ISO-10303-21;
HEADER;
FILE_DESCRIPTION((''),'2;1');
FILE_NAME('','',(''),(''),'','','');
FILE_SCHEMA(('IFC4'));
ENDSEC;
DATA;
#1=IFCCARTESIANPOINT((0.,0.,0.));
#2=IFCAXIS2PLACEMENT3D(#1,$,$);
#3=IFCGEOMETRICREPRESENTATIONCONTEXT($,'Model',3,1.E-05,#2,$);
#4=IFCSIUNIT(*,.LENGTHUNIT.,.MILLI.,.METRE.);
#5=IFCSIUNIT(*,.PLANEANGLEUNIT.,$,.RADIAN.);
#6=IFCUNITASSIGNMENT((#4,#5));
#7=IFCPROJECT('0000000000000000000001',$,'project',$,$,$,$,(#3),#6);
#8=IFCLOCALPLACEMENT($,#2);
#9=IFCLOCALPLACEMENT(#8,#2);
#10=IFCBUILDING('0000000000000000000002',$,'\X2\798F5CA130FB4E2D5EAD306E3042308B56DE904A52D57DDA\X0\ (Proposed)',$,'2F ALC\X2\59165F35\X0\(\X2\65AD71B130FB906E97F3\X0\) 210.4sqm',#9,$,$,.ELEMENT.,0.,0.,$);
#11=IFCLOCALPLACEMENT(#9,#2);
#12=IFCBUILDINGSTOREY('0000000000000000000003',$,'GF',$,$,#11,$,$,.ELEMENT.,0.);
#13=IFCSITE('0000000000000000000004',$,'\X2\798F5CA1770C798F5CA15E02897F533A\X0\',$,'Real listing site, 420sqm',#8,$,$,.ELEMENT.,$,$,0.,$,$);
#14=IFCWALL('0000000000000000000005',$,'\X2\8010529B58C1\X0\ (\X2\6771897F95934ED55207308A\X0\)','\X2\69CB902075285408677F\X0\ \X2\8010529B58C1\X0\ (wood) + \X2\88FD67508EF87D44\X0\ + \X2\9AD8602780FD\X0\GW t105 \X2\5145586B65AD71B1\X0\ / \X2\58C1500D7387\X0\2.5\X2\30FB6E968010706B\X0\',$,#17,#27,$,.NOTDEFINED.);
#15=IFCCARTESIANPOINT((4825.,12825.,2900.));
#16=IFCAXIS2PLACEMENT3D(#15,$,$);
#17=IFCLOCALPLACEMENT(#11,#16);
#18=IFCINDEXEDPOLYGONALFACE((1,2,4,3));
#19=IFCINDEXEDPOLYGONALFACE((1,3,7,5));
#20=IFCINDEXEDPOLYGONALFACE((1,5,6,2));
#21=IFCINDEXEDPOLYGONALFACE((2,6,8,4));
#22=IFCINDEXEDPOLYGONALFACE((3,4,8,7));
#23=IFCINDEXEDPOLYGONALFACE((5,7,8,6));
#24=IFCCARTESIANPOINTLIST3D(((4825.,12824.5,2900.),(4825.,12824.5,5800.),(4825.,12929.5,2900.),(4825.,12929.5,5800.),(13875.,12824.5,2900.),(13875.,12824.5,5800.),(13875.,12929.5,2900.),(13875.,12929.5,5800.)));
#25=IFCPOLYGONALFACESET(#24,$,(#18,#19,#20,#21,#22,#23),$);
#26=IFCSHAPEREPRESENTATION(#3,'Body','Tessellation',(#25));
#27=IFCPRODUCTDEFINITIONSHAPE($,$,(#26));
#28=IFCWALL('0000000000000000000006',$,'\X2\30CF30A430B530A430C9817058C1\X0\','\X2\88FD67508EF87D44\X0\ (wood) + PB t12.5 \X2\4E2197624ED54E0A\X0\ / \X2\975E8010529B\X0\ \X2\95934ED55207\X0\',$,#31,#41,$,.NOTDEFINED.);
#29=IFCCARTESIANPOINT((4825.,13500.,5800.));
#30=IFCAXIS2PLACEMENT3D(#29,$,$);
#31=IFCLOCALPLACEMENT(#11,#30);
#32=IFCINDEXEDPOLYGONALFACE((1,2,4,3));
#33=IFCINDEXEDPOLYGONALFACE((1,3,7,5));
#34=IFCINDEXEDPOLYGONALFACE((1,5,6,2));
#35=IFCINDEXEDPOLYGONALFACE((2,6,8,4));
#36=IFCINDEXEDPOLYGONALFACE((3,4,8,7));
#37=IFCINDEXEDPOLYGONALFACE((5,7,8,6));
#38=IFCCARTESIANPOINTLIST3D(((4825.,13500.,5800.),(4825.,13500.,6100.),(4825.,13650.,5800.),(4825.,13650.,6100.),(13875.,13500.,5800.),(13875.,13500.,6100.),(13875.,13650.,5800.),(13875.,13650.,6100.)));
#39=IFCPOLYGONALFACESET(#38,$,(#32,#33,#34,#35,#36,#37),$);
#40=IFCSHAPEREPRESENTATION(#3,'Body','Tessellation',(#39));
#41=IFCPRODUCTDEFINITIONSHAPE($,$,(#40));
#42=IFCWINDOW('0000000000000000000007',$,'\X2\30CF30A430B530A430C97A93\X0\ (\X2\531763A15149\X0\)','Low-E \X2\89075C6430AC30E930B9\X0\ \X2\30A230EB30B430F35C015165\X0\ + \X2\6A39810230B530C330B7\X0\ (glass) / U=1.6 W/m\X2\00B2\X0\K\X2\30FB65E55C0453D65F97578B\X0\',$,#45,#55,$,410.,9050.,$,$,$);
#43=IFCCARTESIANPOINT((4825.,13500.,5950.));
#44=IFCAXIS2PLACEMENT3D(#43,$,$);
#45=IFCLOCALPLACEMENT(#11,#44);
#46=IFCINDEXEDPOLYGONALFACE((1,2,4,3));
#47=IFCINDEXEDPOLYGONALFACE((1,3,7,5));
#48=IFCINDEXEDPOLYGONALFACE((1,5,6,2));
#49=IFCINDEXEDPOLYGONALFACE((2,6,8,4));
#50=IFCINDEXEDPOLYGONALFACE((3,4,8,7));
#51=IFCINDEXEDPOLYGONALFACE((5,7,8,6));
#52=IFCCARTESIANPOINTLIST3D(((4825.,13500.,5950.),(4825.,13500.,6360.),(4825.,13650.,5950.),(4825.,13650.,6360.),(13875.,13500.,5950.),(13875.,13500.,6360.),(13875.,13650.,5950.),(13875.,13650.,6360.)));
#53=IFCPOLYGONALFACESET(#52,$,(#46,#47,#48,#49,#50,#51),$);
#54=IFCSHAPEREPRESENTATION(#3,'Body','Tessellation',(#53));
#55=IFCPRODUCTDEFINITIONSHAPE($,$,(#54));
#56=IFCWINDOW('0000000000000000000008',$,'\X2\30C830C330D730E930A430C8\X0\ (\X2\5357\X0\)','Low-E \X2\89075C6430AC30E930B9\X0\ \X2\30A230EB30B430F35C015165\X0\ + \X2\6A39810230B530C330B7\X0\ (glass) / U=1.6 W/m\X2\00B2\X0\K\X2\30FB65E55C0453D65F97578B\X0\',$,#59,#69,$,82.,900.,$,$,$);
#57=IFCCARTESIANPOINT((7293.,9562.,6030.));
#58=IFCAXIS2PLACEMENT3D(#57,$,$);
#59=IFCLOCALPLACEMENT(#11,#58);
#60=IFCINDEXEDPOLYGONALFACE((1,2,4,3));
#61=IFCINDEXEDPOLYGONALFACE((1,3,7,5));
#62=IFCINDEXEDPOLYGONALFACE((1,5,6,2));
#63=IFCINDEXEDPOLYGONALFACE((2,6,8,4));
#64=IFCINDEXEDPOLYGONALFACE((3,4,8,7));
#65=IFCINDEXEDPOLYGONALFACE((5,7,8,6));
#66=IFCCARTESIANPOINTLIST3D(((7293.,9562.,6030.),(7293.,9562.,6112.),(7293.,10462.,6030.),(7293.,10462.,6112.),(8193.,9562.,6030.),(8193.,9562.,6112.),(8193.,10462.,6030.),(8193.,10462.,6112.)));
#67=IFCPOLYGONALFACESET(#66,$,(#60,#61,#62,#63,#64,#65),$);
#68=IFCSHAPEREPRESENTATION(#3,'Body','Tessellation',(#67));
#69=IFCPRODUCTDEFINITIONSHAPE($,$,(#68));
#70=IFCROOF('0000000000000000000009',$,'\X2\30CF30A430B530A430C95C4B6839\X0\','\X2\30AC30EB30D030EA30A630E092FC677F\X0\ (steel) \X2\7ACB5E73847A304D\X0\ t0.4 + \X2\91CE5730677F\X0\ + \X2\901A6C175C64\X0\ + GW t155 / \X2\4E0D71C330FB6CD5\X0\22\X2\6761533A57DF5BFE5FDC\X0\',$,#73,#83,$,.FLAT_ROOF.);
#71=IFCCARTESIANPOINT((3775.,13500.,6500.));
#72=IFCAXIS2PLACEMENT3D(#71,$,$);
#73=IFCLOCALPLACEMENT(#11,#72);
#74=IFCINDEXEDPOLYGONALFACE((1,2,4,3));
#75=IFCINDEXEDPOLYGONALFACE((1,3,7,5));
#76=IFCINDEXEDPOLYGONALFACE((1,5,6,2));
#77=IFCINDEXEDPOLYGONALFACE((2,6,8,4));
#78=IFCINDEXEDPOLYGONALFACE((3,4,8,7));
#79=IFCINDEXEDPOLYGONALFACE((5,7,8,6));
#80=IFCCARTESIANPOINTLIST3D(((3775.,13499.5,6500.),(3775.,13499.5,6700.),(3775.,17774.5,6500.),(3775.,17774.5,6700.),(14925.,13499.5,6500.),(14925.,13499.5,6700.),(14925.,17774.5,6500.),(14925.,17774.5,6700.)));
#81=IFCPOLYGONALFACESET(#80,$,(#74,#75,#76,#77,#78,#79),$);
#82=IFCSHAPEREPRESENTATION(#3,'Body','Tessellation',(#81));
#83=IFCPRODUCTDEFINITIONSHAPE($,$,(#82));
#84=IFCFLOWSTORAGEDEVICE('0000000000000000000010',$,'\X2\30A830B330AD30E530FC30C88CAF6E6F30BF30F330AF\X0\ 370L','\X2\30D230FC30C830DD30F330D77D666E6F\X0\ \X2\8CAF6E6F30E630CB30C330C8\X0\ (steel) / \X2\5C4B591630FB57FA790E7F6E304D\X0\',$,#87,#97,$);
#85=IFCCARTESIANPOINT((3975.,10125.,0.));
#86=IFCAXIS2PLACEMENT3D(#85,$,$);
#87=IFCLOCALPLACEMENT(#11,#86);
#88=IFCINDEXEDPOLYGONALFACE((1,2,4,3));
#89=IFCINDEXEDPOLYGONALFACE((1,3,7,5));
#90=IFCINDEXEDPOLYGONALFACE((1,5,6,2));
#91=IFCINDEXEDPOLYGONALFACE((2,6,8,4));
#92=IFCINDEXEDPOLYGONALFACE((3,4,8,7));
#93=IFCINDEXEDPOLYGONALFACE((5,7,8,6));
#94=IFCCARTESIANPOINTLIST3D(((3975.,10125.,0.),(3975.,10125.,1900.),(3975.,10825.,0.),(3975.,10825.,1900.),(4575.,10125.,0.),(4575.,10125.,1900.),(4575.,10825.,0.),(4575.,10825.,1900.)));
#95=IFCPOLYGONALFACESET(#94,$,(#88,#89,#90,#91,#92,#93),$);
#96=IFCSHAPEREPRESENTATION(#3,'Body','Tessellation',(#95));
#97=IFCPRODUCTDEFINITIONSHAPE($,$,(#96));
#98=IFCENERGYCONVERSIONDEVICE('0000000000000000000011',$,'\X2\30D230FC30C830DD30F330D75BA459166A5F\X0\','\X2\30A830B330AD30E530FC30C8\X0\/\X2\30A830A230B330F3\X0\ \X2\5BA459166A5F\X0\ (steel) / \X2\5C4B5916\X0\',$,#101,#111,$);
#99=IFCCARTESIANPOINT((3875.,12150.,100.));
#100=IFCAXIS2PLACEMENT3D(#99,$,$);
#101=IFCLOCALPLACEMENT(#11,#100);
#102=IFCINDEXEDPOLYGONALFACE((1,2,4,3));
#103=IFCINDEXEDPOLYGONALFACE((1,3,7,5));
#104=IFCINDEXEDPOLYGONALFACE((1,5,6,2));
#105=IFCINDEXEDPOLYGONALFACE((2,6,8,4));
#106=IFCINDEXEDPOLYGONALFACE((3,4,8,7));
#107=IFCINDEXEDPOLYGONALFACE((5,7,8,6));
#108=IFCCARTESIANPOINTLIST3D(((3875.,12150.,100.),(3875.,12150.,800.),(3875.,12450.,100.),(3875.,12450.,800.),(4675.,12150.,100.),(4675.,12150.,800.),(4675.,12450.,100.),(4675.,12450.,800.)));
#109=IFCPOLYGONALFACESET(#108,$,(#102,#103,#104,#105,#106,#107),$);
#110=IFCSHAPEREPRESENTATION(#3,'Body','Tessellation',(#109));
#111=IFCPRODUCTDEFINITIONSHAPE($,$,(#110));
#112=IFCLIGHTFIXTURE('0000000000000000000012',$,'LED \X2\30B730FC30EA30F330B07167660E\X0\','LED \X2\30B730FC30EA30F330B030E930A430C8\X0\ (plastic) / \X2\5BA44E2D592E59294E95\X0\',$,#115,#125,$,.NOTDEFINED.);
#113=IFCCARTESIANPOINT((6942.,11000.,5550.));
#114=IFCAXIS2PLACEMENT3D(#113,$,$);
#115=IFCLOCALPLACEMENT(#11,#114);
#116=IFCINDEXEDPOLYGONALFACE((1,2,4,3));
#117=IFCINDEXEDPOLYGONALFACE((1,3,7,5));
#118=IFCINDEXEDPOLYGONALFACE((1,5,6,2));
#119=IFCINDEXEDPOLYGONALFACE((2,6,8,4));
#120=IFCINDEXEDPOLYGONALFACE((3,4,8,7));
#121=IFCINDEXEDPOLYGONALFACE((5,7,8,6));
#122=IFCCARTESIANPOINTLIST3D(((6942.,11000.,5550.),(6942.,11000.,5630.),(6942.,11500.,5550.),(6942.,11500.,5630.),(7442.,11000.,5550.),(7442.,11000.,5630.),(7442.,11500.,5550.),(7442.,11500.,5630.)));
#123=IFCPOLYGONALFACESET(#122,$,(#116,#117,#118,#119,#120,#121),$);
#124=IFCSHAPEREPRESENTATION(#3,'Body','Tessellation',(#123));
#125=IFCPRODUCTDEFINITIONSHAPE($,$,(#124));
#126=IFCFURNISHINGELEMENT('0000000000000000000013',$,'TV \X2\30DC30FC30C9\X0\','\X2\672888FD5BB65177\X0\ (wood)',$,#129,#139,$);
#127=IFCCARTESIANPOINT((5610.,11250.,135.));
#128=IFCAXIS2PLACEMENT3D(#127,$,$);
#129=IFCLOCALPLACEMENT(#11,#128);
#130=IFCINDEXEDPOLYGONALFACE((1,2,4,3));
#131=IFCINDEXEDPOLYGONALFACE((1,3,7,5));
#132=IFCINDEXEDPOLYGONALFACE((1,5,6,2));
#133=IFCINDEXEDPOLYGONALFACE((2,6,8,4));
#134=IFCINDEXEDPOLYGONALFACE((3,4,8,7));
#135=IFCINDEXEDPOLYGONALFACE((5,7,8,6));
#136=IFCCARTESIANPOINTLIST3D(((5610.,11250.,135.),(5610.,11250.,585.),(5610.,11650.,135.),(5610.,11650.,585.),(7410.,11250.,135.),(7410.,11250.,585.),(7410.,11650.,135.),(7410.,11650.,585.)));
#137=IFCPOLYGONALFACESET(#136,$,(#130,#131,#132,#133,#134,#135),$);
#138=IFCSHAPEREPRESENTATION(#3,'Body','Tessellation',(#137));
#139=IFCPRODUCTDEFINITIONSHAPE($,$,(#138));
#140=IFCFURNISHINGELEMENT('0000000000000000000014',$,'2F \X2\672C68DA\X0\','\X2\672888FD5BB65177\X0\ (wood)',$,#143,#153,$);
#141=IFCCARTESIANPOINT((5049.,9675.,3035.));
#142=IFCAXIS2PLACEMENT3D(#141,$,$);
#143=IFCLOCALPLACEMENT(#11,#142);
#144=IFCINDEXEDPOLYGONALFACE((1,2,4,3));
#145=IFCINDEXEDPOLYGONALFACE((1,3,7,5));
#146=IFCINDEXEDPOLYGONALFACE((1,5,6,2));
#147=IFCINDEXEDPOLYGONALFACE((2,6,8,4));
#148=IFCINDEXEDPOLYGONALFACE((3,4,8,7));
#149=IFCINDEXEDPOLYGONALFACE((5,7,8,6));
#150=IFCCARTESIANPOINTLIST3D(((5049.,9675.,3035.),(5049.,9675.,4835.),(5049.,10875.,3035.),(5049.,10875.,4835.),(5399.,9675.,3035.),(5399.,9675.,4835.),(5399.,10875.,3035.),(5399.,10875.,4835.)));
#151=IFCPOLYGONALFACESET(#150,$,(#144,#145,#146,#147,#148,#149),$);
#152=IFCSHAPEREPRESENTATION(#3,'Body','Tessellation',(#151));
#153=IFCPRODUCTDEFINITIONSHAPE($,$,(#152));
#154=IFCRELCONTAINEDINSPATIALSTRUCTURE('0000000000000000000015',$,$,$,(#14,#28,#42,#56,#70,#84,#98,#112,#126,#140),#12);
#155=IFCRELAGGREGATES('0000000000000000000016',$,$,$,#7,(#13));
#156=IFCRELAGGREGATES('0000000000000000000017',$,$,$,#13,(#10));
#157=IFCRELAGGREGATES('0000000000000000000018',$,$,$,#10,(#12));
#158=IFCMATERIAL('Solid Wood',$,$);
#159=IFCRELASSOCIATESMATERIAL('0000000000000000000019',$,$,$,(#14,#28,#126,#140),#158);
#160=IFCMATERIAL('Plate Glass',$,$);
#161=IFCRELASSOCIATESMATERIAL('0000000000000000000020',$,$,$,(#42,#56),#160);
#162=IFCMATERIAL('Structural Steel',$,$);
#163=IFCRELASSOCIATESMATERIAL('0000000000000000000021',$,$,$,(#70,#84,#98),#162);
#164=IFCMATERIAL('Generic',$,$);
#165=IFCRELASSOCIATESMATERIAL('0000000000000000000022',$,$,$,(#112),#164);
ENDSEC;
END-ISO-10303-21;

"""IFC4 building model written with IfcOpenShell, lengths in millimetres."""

from ifc_helpers import new_model, si_unit, frame, frame_2d, origin, place, context, project, spatial, rectangle, extrude, material, element, fill, save


model = new_model("IFC4")

# Units and contexts
model_context = context("Model", 3, precision=1e-05, world=origin())
ifc_project = project(units=[si_unit("LENGTHUNIT", "METRE", prefix="MILLI"), si_unit("PLANEANGLEUNIT", "RADIAN")], contexts=[model_context])

# Site, building, storey
site_placement = place(None, origin())
site = spatial("IfcSite", under=ifc_project, at=site_placement, Name="福岡県福岡市西区", ObjectType="Real listing site, 420sqm", CompositionType="ELEMENT", RefElevation=0.0)
building_placement = place(site_placement, origin())
building = spatial("IfcBuilding", under=site, at=building_placement, Name="福岡・中庭のある回遊動線 (Proposed)", ObjectType="2F ALC外張(断熱・遮音) 210.4sqm", CompositionType="ELEMENT", ElevationOfRefHeight=0.0, ElevationOfTerrain=0.0)
storey_placement = place(building_placement, origin())
storey = spatial("IfcBuildingStorey", under=building, at=storey_placement, Name="GF", CompositionType="ELEMENT", Elevation=0.0)

# Shared definitions
ifc_material_1 = material(Name="Solid Wood")

# Wall
wall_1_placement = place(storey_placement, frame((4825.0, 12825.0, 2900.0)))
element("IfcWall", 1, at=wall_1_placement, inside=storey, material=ifc_material_1, Name="耐力壁 (東西間仕切り)", Description="構造用合板 耐力壁 (wood) + 製材軸組 + 高性能GW t105 充填断熱 / 壁倍率2.5・準耐火", PredefinedType="NOTDEFINED", context=model_context, shape_type="SweptSolid", body=[
    extrude(rectangle(XDim=9050.0, YDim=105.0, at=frame_2d((4525.0, 52.0))), frame((4825.0, 12825.0, 2900.0)), (0.0, 0.0, 1.0), 2900.0),
])

# Wall, opening, window
wall_2_placement = place(storey_placement, frame((4825.0, 13500.0, 5800.0)))
wall_2 = element("IfcWall", 2, at=wall_2_placement, inside=storey, material=ifc_material_1, Name="ハイサイド腰壁", Description="製材軸組 (wood) + PB t12.5 両面仕上 / 非耐力 間仕切", PredefinedType="NOTDEFINED", context=model_context, shape_type="SweptSolid", body=[
    extrude(rectangle(XDim=9050.0, YDim=150.0, at=frame_2d((4525.0, 75.0))), frame((4825.0, 13500.0, 5800.0)), (0.0, 0.0, 1.0), 700.0),
])
opening_1_placement = place(storey_placement, frame((4825.0, 13500.0, 5950.0)))
opening_1 = element("IfcOpeningElement", 3, at=opening_1_placement, cuts=wall_2, PredefinedType="NOTDEFINED", context=model_context, shape_type="SweptSolid", body=[
    extrude(rectangle(XDim=9050.0, YDim=150.0, at=frame_2d((4525.0, 75.0))), frame((4825.0, 13500.0, 5950.0)), (0.0, 0.0, 1.0), 410.0),
])
ifc_material_2 = material(Name="Plate Glass")
window_1_placement = place(storey_placement, frame((4825.0, 13500.0, 5950.0)))
window_1 = element("IfcWindow", 4, at=window_1_placement, inside=storey, material=ifc_material_2, Name="ハイサイド窓 (北採光)", Description="Low-E 複層ガラス アルゴン封入 + 樹脂サッシ (glass) / U=1.6 W/m²K・日射取得型", OverallHeight=410.0, OverallWidth=9050.0, context=model_context, shape_type="SweptSolid", body=[
    extrude(rectangle(XDim=9050.0, YDim=150.0, at=frame_2d((4525.0, 75.0))), frame((4825.0, 13500.0, 5950.0)), (0.0, 0.0, 1.0), 410.0),
])
fill(opening_1, window_1)

# Window
window_2_placement = place(storey_placement, frame((7293.0, 9562.0, 6030.0)))
element("IfcWindow", 5, at=window_2_placement, inside=storey, material=ifc_material_2, Name="トップライト (南)", Description="Low-E 複層ガラス アルゴン封入 + 樹脂サッシ (glass) / U=1.6 W/m²K・日射取得型", OverallHeight=82.0, OverallWidth=900.0, context=model_context, shape_type="SweptSolid", body=[
    extrude(rectangle(XDim=900.0, YDim=900.0, at=frame_2d((450.0, 450.0))), frame((7293.0, 9562.0, 6030.0)), (0.0, 0.0, 1.0), 82.0),
])

# Roof
ifc_material_3 = material(Name="Structural Steel")
roof_placement = place(storey_placement, frame((3775.0, 13500.0, 6500.0)))
element("IfcRoof", 6, at=roof_placement, inside=storey, material=ifc_material_3, Name="ハイサイド屋根", Description="ガルバリウム鋼板 (steel) 立平葺き t0.4 + 野地板 + 通気層 + GW t155 / 不燃・法22条区域対応", PredefinedType="FLAT_ROOF", context=model_context, shape_type="SweptSolid", body=[
    extrude(rectangle(XDim=11150.0, YDim=4275.0, at=frame_2d((5575.0, 2137.0))), frame((3775.0, 13500.0, 6500.0)), (0.0, 0.0, 1.0), 200.0),
])

# Flow storage device
flow_storage_device_placement = place(storey_placement, frame((3975.0, 10125.0, 0.0)))
element("IfcFlowStorageDevice", 7, at=flow_storage_device_placement, inside=storey, material=ifc_material_3, Name="エコキュート貯湯タンク 370L", Description="ヒートポンプ給湯 貯湯ユニット (steel) / 屋外・基礎置き", context=model_context, shape_type="SweptSolid", body=[
    extrude(rectangle(XDim=600.0, YDim=700.0, at=frame_2d((300.0, 350.0))), frame((3975.0, 10125.0, 0.0)), (0.0, 0.0, 1.0), 1900.0),
])

# Energy conversion device
energy_conversion_device_placement = place(storey_placement, frame((3875.0, 12150.0, 100.0)))
element("IfcEnergyConversionDevice", 8, at=energy_conversion_device_placement, inside=storey, material=ifc_material_3, Name="ヒートポンプ室外機", Description="エコキュート/エアコン 室外機 (steel) / 屋外", context=model_context, shape_type="SweptSolid", body=[
    extrude(rectangle(XDim=800.0, YDim=300.0, at=frame_2d((400.0, 150.0))), frame((3875.0, 12150.0, 100.0)), (0.0, 0.0, 1.0), 700.0),
])

# Light fixture
ifc_material_4 = material(Name="Generic")
light_fixture_placement = place(storey_placement, frame((6942.0, 11000.0, 5550.0)))
element("IfcLightFixture", 9, at=light_fixture_placement, inside=storey, material=ifc_material_4, Name="LED シーリング照明", Description="LED シーリングライト (plastic) / 室中央天井", PredefinedType="NOTDEFINED", context=model_context, shape_type="SweptSolid", body=[
    extrude(rectangle(XDim=500.0, YDim=500.0, at=frame_2d((250.0, 250.0))), frame((6942.0, 11000.0, 5550.0)), (0.0, 0.0, 1.0), 80.0),
])

# Furnishing elements
furnishing_1_placement = place(storey_placement, frame((5610.0, 11250.0, 135.0)))
element("IfcFurnishingElement", 10, at=furnishing_1_placement, inside=storey, material=ifc_material_1, Name="TV ボード", Description="木製家具 (wood)", context=model_context, shape_type="SweptSolid", body=[
    extrude(rectangle(XDim=1800.0, YDim=400.0, at=frame_2d((900.0, 200.0))), frame((5610.0, 11250.0, 135.0)), (0.0, 0.0, 1.0), 450.0),
])
furnishing_2_placement = place(storey_placement, frame((5049.0, 9675.0, 3035.0)))
element("IfcFurnishingElement", 11, at=furnishing_2_placement, inside=storey, material=ifc_material_1, Name="2F 本棚", Description="木製家具 (wood)", context=model_context, shape_type="SweptSolid", body=[
    extrude(rectangle(XDim=350.0, YDim=1200.0, at=frame_2d((175.0, 600.0))), frame((5049.0, 9675.0, 3035.0)), (0.0, 0.0, 1.0), 1800.0),
])

save(model, "model.ifc")
